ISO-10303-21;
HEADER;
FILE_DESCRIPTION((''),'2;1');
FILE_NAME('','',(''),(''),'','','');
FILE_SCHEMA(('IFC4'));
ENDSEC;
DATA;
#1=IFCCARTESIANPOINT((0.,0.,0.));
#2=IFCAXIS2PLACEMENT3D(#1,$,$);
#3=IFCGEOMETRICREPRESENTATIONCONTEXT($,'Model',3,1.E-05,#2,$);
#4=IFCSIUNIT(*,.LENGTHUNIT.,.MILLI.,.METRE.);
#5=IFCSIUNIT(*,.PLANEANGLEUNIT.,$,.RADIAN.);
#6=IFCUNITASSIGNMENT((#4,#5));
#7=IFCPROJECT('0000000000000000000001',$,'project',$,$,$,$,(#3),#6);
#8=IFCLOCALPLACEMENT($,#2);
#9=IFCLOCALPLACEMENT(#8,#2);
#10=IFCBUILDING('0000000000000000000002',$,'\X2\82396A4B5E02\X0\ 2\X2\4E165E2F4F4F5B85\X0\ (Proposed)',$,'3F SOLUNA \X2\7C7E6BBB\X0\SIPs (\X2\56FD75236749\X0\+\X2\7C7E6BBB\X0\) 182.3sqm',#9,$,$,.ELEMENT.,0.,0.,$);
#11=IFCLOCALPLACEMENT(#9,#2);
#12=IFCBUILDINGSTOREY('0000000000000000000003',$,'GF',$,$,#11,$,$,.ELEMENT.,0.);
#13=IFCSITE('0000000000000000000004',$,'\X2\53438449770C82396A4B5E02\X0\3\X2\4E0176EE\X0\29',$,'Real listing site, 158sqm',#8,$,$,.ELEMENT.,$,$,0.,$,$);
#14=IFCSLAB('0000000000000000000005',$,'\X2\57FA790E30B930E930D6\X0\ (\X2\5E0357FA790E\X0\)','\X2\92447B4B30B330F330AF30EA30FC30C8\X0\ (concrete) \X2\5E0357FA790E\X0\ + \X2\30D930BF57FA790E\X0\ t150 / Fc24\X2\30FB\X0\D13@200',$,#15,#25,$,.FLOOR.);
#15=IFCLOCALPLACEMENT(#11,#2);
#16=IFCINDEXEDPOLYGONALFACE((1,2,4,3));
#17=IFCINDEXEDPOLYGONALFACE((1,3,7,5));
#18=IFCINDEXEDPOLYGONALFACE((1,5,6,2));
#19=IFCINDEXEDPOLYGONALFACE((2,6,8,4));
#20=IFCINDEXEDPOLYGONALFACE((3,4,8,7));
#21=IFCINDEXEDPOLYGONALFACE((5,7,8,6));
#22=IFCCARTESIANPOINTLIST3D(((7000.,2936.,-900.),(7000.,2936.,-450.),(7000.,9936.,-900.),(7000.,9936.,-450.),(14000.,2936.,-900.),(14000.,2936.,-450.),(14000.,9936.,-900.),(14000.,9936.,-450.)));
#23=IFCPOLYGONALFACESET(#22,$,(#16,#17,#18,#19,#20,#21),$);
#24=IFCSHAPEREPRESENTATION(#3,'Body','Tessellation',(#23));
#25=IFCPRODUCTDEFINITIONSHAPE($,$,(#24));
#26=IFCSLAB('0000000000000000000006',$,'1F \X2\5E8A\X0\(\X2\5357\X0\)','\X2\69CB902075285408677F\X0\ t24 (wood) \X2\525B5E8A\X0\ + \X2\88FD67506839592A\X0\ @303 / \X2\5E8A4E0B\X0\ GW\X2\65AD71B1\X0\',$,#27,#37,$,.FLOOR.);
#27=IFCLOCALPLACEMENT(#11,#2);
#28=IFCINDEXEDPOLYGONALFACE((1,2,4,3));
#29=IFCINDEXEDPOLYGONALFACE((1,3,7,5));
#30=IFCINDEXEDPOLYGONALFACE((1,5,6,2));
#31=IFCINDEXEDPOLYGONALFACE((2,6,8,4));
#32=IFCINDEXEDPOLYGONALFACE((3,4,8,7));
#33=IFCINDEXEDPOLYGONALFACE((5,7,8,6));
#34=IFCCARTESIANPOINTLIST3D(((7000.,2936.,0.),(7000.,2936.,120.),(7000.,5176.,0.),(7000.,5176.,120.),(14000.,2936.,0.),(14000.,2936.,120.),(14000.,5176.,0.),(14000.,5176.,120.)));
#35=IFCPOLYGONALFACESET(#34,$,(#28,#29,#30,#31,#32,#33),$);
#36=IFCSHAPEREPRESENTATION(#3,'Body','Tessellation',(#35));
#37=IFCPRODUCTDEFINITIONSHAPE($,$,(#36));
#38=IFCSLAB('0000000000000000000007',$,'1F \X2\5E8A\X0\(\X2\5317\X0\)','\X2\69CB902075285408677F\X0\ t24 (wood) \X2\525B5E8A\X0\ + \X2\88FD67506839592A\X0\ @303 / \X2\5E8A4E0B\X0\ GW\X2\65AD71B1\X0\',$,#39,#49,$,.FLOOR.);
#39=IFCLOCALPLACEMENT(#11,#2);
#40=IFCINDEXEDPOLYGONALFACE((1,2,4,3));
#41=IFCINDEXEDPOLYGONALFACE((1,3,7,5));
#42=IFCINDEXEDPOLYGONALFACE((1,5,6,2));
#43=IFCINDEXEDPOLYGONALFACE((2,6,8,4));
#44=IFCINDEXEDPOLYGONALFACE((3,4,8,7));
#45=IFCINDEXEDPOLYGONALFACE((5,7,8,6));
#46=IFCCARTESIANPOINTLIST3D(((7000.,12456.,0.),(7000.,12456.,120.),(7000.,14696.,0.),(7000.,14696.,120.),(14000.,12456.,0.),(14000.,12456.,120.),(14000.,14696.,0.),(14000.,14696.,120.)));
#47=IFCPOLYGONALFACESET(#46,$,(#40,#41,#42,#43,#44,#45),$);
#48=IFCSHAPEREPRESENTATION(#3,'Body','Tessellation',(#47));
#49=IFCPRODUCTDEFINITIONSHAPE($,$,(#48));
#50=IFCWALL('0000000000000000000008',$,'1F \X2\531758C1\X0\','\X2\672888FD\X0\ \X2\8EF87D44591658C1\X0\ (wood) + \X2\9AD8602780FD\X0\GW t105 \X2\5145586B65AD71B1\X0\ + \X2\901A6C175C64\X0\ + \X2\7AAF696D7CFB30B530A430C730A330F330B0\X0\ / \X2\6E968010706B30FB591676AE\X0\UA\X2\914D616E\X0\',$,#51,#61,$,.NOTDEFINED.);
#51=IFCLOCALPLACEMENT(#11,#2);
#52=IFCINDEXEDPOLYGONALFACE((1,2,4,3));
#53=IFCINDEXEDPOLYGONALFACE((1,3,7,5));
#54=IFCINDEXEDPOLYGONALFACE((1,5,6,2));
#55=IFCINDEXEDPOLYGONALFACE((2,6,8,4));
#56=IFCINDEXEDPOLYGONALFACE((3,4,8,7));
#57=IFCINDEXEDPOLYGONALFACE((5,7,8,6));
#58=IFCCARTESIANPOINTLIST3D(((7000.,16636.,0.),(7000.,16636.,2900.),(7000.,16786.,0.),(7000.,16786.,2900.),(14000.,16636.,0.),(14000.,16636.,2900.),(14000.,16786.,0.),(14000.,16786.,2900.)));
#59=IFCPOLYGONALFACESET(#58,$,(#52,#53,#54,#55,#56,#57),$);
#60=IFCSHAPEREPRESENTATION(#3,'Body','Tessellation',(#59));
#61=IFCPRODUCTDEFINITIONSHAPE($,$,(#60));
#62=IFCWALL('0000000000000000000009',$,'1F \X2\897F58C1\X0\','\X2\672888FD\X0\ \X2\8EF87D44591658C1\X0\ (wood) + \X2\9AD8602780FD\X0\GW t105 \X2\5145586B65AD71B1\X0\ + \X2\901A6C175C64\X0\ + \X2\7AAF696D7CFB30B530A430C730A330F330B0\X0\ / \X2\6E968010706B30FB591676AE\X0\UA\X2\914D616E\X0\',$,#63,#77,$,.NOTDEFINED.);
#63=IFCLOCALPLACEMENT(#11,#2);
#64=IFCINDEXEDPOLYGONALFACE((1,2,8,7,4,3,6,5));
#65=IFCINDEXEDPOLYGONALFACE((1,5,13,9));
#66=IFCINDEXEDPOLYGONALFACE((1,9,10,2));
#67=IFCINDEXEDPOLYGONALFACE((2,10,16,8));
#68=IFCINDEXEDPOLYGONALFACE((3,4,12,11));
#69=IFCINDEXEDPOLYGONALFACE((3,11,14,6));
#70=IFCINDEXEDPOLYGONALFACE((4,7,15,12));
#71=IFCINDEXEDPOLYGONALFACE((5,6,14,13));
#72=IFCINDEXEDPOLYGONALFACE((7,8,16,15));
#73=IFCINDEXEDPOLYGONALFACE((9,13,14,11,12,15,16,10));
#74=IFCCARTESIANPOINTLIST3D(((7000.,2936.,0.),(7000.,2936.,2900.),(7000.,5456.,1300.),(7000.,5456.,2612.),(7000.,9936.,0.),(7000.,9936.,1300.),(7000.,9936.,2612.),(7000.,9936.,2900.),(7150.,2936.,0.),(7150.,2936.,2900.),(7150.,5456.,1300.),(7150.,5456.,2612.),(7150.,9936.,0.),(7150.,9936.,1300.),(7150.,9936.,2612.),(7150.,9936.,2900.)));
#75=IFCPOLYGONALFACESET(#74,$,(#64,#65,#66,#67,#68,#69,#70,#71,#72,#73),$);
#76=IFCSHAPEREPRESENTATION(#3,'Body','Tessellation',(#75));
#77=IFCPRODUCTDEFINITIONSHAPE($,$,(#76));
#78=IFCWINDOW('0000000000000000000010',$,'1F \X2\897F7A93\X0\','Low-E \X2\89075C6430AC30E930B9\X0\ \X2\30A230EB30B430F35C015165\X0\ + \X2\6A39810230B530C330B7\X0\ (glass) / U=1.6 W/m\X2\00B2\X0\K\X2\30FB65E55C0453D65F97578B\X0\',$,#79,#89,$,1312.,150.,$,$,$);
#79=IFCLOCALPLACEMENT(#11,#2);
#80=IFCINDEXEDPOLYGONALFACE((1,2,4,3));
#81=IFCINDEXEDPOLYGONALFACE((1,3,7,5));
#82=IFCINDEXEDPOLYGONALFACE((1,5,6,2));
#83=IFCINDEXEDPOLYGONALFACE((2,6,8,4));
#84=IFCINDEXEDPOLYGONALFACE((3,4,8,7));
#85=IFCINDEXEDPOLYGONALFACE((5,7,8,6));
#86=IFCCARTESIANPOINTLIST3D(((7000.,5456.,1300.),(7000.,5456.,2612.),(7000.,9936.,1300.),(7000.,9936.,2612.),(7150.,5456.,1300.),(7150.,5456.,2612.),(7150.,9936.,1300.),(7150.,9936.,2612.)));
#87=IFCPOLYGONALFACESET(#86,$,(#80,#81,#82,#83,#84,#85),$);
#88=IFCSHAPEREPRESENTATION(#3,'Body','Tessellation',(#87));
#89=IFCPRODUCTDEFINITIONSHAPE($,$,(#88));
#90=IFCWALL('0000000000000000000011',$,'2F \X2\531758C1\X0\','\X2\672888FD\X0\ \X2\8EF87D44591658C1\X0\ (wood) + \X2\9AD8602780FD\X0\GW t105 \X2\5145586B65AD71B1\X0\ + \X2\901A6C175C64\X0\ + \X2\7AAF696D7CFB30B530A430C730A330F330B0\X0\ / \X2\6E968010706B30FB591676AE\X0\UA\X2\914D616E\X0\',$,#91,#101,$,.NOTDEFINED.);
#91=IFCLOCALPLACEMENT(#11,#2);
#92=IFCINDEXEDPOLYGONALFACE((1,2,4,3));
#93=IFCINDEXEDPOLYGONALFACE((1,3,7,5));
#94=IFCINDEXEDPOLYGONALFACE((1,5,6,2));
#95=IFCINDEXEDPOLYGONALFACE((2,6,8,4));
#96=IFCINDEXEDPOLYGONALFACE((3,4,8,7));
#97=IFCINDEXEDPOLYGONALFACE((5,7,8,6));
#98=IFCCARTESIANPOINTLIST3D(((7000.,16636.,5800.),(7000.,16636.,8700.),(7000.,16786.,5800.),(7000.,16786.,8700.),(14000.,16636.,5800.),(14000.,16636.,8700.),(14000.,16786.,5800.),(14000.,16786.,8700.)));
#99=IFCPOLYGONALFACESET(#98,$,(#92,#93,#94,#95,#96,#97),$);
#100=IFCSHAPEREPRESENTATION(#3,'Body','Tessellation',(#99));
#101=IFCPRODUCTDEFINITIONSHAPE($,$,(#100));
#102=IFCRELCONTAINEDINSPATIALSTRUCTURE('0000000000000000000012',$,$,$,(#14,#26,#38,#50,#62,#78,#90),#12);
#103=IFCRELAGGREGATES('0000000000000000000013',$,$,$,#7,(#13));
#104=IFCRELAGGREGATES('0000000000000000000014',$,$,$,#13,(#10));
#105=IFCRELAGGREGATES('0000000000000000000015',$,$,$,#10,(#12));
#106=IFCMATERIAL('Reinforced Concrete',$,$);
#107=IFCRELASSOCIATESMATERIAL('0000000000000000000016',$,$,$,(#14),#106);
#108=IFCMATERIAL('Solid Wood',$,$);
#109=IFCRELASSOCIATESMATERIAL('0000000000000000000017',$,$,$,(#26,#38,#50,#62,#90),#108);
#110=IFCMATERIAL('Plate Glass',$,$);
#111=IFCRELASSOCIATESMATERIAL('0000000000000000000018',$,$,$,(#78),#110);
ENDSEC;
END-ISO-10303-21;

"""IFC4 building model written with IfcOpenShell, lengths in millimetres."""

from ifc_helpers import new_model, si_unit, frame, frame_2d, origin, place, context, project, spatial, rectangle, extrude, material, element, fill, save


model = new_model("IFC4")

# Units and contexts
model_context = context("Model", 3, precision=1e-05, world=origin())
ifc_project = project(units=[si_unit("LENGTHUNIT", "METRE", prefix="MILLI"), si_unit("PLANEANGLEUNIT", "RADIAN")], contexts=[model_context])

# Site, building, storey
site_placement = place(None, origin())
site = spatial("IfcSite", under=ifc_project, at=site_placement, Name="千葉県船橋市3丁目29", ObjectType="Real listing site, 158sqm", CompositionType="ELEMENT", RefElevation=0.0)
building_placement = place(site_placement, origin())
building = spatial("IfcBuilding", under=site, at=building_placement, Name="船橋市 2世帯住宅 (Proposed)", ObjectType="3F SOLUNA 籾殻SIPs (国産杉+籾殻) 182.3sqm", CompositionType="ELEMENT", ElevationOfRefHeight=0.0, ElevationOfTerrain=0.0)
storey_placement = place(building_placement, origin())
storey = spatial("IfcBuildingStorey", under=building, at=storey_placement, Name="GF", CompositionType="ELEMENT", Elevation=0.0)

# Slabs
ifc_material_1 = material(Name="Reinforced Concrete")
slab_1_placement = place(storey_placement, frame((3500.0, 1468.0, -450.0)))
element("IfcSlab", 1, at=slab_1_placement, inside=storey, material=ifc_material_1, Name="基礎スラブ (布基礎)", Description="鉄筋コンクリート (concrete) 布基礎 + ベタ基礎 t150 / Fc24・D13@200", PredefinedType="FLOOR", context=model_context, shape_type="SweptSolid", body=[
    extrude(rectangle(XDim=7000.0, YDim=7000.0, at=frame_2d((3500.0, 3500.0))), frame((3500.0, 1468.0, -450.0)), (0.0, 0.0, 1.0), 450.0),
])
ifc_material_2 = material(Name="Solid Wood")
slab_2_placement = place(storey_placement, frame((3500.0, 1468.0, 0.0)))
element("IfcSlab", 2, at=slab_2_placement, inside=storey, material=ifc_material_2, Name="1F 床(南)", Description="構造用合板 t24 (wood) 剛床 + 製材根太 @303 / 床下 GW断熱", PredefinedType="FLOOR", context=model_context, shape_type="SweptSolid", body=[
    extrude(rectangle(XDim=7000.0, YDim=2240.0, at=frame_2d((3500.0, 1120.0))), frame((3500.0, 1468.0, 0.0)), (0.0, 0.0, 1.0), 120.0),
])
slab_3_placement = place(storey_placement, frame((3500.0, 6228.0, 0.0)))
element("IfcSlab", 3, at=slab_3_placement, inside=storey, material=ifc_material_2, Name="1F 床(北)", Description="構造用合板 t24 (wood) 剛床 + 製材根太 @303 / 床下 GW断熱", PredefinedType="FLOOR", context=model_context, shape_type="SweptSolid", body=[
    extrude(rectangle(XDim=7000.0, YDim=2240.0, at=frame_2d((3500.0, 1120.0))), frame((3500.0, 6228.0, 0.0)), (0.0, 0.0, 1.0), 120.0),
])

# Shared definitions
ifc_material_3 = material(Name="Plate Glass")

# Wall
wall_1_placement = place(storey_placement, frame((3500.0, 8318.0, 0.0)))
element("IfcWall", 4, at=wall_1_placement, inside=storey, material=ifc_material_2, Name="1F 北壁", Description="木製 軸組外壁 (wood) + 高性能GW t105 充填断熱 + 通気層 + 窯業系サイディング / 準耐火・外皮UA配慮", PredefinedType="NOTDEFINED", context=model_context, shape_type="SweptSolid", body=[
    extrude(rectangle(XDim=7000.0, YDim=150.0, at=frame_2d((3500.0, 75.0))), frame((3500.0, 8318.0, 0.0)), (0.0, 0.0, 1.0), 2900.0),
])

# Wall, opening, window
wall_2_placement = place(storey_placement, frame((3500.0, 1468.0, 0.0)))
wall_2 = element("IfcWall", 5, at=wall_2_placement, inside=storey, material=ifc_material_2, Name="1F 西壁", Description="木製 軸組外壁 (wood) + 高性能GW t105 充填断熱 + 通気層 + 窯業系サイディング / 準耐火・外皮UA配慮", PredefinedType="NOTDEFINED", context=model_context, shape_type="SweptSolid", body=[
    extrude(rectangle(XDim=150.0, YDim=7000.0, at=frame_2d((75.0, 3500.0))), frame((3500.0, 1468.0, 0.0)), (0.0, 0.0, 1.0), 2900.0),
])
opening_1_placement = place(storey_placement, frame((3500.0, 2728.0, 650.0)))
opening_1 = element("IfcOpeningElement", 6, at=opening_1_placement, cuts=wall_2, PredefinedType="NOTDEFINED", context=model_context, shape_type="SweptSolid", body=[
    extrude(rectangle(XDim=150.0, YDim=4480.0, at=frame_2d((75.0, 2240.0))), frame((3500.0, 2728.0, 650.0)), (0.0, 0.0, 1.0), 1312.0),
])
window_1_placement = place(storey_placement, frame((3500.0, 2728.0, 650.0)))
window_1 = element("IfcWindow", 7, at=window_1_placement, inside=storey, material=ifc_material_3, Name="1F 西窓", Description="Low-E 複層ガラス アルゴン封入 + 樹脂サッシ (glass) / U=1.6 W/m²K・日射取得型", OverallHeight=1312.0, OverallWidth=150.0, context=model_context, shape_type="SweptSolid", body=[
    extrude(rectangle(XDim=150.0, YDim=4480.0, at=frame_2d((75.0, 2240.0))), frame((3500.0, 2728.0, 650.0)), (0.0, 0.0, 1.0), 1312.0),
])
fill(opening_1, window_1)

# Wall
wall_3_placement = place(storey_placement, frame((3500.0, 8318.0, 2900.0)))
element("IfcWall", 8, at=wall_3_placement, inside=storey, material=ifc_material_2, Name="2F 北壁", Description="木製 軸組外壁 (wood) + 高性能GW t105 充填断熱 + 通気層 + 窯業系サイディング / 準耐火・外皮UA配慮", PredefinedType="NOTDEFINED", context=model_context, shape_type="SweptSolid", body=[
    extrude(rectangle(XDim=7000.0, YDim=150.0, at=frame_2d((3500.0, 75.0))), frame((3500.0, 8318.0, 2900.0)), (0.0, 0.0, 1.0), 2900.0),
])

save(model, "model.ifc")
